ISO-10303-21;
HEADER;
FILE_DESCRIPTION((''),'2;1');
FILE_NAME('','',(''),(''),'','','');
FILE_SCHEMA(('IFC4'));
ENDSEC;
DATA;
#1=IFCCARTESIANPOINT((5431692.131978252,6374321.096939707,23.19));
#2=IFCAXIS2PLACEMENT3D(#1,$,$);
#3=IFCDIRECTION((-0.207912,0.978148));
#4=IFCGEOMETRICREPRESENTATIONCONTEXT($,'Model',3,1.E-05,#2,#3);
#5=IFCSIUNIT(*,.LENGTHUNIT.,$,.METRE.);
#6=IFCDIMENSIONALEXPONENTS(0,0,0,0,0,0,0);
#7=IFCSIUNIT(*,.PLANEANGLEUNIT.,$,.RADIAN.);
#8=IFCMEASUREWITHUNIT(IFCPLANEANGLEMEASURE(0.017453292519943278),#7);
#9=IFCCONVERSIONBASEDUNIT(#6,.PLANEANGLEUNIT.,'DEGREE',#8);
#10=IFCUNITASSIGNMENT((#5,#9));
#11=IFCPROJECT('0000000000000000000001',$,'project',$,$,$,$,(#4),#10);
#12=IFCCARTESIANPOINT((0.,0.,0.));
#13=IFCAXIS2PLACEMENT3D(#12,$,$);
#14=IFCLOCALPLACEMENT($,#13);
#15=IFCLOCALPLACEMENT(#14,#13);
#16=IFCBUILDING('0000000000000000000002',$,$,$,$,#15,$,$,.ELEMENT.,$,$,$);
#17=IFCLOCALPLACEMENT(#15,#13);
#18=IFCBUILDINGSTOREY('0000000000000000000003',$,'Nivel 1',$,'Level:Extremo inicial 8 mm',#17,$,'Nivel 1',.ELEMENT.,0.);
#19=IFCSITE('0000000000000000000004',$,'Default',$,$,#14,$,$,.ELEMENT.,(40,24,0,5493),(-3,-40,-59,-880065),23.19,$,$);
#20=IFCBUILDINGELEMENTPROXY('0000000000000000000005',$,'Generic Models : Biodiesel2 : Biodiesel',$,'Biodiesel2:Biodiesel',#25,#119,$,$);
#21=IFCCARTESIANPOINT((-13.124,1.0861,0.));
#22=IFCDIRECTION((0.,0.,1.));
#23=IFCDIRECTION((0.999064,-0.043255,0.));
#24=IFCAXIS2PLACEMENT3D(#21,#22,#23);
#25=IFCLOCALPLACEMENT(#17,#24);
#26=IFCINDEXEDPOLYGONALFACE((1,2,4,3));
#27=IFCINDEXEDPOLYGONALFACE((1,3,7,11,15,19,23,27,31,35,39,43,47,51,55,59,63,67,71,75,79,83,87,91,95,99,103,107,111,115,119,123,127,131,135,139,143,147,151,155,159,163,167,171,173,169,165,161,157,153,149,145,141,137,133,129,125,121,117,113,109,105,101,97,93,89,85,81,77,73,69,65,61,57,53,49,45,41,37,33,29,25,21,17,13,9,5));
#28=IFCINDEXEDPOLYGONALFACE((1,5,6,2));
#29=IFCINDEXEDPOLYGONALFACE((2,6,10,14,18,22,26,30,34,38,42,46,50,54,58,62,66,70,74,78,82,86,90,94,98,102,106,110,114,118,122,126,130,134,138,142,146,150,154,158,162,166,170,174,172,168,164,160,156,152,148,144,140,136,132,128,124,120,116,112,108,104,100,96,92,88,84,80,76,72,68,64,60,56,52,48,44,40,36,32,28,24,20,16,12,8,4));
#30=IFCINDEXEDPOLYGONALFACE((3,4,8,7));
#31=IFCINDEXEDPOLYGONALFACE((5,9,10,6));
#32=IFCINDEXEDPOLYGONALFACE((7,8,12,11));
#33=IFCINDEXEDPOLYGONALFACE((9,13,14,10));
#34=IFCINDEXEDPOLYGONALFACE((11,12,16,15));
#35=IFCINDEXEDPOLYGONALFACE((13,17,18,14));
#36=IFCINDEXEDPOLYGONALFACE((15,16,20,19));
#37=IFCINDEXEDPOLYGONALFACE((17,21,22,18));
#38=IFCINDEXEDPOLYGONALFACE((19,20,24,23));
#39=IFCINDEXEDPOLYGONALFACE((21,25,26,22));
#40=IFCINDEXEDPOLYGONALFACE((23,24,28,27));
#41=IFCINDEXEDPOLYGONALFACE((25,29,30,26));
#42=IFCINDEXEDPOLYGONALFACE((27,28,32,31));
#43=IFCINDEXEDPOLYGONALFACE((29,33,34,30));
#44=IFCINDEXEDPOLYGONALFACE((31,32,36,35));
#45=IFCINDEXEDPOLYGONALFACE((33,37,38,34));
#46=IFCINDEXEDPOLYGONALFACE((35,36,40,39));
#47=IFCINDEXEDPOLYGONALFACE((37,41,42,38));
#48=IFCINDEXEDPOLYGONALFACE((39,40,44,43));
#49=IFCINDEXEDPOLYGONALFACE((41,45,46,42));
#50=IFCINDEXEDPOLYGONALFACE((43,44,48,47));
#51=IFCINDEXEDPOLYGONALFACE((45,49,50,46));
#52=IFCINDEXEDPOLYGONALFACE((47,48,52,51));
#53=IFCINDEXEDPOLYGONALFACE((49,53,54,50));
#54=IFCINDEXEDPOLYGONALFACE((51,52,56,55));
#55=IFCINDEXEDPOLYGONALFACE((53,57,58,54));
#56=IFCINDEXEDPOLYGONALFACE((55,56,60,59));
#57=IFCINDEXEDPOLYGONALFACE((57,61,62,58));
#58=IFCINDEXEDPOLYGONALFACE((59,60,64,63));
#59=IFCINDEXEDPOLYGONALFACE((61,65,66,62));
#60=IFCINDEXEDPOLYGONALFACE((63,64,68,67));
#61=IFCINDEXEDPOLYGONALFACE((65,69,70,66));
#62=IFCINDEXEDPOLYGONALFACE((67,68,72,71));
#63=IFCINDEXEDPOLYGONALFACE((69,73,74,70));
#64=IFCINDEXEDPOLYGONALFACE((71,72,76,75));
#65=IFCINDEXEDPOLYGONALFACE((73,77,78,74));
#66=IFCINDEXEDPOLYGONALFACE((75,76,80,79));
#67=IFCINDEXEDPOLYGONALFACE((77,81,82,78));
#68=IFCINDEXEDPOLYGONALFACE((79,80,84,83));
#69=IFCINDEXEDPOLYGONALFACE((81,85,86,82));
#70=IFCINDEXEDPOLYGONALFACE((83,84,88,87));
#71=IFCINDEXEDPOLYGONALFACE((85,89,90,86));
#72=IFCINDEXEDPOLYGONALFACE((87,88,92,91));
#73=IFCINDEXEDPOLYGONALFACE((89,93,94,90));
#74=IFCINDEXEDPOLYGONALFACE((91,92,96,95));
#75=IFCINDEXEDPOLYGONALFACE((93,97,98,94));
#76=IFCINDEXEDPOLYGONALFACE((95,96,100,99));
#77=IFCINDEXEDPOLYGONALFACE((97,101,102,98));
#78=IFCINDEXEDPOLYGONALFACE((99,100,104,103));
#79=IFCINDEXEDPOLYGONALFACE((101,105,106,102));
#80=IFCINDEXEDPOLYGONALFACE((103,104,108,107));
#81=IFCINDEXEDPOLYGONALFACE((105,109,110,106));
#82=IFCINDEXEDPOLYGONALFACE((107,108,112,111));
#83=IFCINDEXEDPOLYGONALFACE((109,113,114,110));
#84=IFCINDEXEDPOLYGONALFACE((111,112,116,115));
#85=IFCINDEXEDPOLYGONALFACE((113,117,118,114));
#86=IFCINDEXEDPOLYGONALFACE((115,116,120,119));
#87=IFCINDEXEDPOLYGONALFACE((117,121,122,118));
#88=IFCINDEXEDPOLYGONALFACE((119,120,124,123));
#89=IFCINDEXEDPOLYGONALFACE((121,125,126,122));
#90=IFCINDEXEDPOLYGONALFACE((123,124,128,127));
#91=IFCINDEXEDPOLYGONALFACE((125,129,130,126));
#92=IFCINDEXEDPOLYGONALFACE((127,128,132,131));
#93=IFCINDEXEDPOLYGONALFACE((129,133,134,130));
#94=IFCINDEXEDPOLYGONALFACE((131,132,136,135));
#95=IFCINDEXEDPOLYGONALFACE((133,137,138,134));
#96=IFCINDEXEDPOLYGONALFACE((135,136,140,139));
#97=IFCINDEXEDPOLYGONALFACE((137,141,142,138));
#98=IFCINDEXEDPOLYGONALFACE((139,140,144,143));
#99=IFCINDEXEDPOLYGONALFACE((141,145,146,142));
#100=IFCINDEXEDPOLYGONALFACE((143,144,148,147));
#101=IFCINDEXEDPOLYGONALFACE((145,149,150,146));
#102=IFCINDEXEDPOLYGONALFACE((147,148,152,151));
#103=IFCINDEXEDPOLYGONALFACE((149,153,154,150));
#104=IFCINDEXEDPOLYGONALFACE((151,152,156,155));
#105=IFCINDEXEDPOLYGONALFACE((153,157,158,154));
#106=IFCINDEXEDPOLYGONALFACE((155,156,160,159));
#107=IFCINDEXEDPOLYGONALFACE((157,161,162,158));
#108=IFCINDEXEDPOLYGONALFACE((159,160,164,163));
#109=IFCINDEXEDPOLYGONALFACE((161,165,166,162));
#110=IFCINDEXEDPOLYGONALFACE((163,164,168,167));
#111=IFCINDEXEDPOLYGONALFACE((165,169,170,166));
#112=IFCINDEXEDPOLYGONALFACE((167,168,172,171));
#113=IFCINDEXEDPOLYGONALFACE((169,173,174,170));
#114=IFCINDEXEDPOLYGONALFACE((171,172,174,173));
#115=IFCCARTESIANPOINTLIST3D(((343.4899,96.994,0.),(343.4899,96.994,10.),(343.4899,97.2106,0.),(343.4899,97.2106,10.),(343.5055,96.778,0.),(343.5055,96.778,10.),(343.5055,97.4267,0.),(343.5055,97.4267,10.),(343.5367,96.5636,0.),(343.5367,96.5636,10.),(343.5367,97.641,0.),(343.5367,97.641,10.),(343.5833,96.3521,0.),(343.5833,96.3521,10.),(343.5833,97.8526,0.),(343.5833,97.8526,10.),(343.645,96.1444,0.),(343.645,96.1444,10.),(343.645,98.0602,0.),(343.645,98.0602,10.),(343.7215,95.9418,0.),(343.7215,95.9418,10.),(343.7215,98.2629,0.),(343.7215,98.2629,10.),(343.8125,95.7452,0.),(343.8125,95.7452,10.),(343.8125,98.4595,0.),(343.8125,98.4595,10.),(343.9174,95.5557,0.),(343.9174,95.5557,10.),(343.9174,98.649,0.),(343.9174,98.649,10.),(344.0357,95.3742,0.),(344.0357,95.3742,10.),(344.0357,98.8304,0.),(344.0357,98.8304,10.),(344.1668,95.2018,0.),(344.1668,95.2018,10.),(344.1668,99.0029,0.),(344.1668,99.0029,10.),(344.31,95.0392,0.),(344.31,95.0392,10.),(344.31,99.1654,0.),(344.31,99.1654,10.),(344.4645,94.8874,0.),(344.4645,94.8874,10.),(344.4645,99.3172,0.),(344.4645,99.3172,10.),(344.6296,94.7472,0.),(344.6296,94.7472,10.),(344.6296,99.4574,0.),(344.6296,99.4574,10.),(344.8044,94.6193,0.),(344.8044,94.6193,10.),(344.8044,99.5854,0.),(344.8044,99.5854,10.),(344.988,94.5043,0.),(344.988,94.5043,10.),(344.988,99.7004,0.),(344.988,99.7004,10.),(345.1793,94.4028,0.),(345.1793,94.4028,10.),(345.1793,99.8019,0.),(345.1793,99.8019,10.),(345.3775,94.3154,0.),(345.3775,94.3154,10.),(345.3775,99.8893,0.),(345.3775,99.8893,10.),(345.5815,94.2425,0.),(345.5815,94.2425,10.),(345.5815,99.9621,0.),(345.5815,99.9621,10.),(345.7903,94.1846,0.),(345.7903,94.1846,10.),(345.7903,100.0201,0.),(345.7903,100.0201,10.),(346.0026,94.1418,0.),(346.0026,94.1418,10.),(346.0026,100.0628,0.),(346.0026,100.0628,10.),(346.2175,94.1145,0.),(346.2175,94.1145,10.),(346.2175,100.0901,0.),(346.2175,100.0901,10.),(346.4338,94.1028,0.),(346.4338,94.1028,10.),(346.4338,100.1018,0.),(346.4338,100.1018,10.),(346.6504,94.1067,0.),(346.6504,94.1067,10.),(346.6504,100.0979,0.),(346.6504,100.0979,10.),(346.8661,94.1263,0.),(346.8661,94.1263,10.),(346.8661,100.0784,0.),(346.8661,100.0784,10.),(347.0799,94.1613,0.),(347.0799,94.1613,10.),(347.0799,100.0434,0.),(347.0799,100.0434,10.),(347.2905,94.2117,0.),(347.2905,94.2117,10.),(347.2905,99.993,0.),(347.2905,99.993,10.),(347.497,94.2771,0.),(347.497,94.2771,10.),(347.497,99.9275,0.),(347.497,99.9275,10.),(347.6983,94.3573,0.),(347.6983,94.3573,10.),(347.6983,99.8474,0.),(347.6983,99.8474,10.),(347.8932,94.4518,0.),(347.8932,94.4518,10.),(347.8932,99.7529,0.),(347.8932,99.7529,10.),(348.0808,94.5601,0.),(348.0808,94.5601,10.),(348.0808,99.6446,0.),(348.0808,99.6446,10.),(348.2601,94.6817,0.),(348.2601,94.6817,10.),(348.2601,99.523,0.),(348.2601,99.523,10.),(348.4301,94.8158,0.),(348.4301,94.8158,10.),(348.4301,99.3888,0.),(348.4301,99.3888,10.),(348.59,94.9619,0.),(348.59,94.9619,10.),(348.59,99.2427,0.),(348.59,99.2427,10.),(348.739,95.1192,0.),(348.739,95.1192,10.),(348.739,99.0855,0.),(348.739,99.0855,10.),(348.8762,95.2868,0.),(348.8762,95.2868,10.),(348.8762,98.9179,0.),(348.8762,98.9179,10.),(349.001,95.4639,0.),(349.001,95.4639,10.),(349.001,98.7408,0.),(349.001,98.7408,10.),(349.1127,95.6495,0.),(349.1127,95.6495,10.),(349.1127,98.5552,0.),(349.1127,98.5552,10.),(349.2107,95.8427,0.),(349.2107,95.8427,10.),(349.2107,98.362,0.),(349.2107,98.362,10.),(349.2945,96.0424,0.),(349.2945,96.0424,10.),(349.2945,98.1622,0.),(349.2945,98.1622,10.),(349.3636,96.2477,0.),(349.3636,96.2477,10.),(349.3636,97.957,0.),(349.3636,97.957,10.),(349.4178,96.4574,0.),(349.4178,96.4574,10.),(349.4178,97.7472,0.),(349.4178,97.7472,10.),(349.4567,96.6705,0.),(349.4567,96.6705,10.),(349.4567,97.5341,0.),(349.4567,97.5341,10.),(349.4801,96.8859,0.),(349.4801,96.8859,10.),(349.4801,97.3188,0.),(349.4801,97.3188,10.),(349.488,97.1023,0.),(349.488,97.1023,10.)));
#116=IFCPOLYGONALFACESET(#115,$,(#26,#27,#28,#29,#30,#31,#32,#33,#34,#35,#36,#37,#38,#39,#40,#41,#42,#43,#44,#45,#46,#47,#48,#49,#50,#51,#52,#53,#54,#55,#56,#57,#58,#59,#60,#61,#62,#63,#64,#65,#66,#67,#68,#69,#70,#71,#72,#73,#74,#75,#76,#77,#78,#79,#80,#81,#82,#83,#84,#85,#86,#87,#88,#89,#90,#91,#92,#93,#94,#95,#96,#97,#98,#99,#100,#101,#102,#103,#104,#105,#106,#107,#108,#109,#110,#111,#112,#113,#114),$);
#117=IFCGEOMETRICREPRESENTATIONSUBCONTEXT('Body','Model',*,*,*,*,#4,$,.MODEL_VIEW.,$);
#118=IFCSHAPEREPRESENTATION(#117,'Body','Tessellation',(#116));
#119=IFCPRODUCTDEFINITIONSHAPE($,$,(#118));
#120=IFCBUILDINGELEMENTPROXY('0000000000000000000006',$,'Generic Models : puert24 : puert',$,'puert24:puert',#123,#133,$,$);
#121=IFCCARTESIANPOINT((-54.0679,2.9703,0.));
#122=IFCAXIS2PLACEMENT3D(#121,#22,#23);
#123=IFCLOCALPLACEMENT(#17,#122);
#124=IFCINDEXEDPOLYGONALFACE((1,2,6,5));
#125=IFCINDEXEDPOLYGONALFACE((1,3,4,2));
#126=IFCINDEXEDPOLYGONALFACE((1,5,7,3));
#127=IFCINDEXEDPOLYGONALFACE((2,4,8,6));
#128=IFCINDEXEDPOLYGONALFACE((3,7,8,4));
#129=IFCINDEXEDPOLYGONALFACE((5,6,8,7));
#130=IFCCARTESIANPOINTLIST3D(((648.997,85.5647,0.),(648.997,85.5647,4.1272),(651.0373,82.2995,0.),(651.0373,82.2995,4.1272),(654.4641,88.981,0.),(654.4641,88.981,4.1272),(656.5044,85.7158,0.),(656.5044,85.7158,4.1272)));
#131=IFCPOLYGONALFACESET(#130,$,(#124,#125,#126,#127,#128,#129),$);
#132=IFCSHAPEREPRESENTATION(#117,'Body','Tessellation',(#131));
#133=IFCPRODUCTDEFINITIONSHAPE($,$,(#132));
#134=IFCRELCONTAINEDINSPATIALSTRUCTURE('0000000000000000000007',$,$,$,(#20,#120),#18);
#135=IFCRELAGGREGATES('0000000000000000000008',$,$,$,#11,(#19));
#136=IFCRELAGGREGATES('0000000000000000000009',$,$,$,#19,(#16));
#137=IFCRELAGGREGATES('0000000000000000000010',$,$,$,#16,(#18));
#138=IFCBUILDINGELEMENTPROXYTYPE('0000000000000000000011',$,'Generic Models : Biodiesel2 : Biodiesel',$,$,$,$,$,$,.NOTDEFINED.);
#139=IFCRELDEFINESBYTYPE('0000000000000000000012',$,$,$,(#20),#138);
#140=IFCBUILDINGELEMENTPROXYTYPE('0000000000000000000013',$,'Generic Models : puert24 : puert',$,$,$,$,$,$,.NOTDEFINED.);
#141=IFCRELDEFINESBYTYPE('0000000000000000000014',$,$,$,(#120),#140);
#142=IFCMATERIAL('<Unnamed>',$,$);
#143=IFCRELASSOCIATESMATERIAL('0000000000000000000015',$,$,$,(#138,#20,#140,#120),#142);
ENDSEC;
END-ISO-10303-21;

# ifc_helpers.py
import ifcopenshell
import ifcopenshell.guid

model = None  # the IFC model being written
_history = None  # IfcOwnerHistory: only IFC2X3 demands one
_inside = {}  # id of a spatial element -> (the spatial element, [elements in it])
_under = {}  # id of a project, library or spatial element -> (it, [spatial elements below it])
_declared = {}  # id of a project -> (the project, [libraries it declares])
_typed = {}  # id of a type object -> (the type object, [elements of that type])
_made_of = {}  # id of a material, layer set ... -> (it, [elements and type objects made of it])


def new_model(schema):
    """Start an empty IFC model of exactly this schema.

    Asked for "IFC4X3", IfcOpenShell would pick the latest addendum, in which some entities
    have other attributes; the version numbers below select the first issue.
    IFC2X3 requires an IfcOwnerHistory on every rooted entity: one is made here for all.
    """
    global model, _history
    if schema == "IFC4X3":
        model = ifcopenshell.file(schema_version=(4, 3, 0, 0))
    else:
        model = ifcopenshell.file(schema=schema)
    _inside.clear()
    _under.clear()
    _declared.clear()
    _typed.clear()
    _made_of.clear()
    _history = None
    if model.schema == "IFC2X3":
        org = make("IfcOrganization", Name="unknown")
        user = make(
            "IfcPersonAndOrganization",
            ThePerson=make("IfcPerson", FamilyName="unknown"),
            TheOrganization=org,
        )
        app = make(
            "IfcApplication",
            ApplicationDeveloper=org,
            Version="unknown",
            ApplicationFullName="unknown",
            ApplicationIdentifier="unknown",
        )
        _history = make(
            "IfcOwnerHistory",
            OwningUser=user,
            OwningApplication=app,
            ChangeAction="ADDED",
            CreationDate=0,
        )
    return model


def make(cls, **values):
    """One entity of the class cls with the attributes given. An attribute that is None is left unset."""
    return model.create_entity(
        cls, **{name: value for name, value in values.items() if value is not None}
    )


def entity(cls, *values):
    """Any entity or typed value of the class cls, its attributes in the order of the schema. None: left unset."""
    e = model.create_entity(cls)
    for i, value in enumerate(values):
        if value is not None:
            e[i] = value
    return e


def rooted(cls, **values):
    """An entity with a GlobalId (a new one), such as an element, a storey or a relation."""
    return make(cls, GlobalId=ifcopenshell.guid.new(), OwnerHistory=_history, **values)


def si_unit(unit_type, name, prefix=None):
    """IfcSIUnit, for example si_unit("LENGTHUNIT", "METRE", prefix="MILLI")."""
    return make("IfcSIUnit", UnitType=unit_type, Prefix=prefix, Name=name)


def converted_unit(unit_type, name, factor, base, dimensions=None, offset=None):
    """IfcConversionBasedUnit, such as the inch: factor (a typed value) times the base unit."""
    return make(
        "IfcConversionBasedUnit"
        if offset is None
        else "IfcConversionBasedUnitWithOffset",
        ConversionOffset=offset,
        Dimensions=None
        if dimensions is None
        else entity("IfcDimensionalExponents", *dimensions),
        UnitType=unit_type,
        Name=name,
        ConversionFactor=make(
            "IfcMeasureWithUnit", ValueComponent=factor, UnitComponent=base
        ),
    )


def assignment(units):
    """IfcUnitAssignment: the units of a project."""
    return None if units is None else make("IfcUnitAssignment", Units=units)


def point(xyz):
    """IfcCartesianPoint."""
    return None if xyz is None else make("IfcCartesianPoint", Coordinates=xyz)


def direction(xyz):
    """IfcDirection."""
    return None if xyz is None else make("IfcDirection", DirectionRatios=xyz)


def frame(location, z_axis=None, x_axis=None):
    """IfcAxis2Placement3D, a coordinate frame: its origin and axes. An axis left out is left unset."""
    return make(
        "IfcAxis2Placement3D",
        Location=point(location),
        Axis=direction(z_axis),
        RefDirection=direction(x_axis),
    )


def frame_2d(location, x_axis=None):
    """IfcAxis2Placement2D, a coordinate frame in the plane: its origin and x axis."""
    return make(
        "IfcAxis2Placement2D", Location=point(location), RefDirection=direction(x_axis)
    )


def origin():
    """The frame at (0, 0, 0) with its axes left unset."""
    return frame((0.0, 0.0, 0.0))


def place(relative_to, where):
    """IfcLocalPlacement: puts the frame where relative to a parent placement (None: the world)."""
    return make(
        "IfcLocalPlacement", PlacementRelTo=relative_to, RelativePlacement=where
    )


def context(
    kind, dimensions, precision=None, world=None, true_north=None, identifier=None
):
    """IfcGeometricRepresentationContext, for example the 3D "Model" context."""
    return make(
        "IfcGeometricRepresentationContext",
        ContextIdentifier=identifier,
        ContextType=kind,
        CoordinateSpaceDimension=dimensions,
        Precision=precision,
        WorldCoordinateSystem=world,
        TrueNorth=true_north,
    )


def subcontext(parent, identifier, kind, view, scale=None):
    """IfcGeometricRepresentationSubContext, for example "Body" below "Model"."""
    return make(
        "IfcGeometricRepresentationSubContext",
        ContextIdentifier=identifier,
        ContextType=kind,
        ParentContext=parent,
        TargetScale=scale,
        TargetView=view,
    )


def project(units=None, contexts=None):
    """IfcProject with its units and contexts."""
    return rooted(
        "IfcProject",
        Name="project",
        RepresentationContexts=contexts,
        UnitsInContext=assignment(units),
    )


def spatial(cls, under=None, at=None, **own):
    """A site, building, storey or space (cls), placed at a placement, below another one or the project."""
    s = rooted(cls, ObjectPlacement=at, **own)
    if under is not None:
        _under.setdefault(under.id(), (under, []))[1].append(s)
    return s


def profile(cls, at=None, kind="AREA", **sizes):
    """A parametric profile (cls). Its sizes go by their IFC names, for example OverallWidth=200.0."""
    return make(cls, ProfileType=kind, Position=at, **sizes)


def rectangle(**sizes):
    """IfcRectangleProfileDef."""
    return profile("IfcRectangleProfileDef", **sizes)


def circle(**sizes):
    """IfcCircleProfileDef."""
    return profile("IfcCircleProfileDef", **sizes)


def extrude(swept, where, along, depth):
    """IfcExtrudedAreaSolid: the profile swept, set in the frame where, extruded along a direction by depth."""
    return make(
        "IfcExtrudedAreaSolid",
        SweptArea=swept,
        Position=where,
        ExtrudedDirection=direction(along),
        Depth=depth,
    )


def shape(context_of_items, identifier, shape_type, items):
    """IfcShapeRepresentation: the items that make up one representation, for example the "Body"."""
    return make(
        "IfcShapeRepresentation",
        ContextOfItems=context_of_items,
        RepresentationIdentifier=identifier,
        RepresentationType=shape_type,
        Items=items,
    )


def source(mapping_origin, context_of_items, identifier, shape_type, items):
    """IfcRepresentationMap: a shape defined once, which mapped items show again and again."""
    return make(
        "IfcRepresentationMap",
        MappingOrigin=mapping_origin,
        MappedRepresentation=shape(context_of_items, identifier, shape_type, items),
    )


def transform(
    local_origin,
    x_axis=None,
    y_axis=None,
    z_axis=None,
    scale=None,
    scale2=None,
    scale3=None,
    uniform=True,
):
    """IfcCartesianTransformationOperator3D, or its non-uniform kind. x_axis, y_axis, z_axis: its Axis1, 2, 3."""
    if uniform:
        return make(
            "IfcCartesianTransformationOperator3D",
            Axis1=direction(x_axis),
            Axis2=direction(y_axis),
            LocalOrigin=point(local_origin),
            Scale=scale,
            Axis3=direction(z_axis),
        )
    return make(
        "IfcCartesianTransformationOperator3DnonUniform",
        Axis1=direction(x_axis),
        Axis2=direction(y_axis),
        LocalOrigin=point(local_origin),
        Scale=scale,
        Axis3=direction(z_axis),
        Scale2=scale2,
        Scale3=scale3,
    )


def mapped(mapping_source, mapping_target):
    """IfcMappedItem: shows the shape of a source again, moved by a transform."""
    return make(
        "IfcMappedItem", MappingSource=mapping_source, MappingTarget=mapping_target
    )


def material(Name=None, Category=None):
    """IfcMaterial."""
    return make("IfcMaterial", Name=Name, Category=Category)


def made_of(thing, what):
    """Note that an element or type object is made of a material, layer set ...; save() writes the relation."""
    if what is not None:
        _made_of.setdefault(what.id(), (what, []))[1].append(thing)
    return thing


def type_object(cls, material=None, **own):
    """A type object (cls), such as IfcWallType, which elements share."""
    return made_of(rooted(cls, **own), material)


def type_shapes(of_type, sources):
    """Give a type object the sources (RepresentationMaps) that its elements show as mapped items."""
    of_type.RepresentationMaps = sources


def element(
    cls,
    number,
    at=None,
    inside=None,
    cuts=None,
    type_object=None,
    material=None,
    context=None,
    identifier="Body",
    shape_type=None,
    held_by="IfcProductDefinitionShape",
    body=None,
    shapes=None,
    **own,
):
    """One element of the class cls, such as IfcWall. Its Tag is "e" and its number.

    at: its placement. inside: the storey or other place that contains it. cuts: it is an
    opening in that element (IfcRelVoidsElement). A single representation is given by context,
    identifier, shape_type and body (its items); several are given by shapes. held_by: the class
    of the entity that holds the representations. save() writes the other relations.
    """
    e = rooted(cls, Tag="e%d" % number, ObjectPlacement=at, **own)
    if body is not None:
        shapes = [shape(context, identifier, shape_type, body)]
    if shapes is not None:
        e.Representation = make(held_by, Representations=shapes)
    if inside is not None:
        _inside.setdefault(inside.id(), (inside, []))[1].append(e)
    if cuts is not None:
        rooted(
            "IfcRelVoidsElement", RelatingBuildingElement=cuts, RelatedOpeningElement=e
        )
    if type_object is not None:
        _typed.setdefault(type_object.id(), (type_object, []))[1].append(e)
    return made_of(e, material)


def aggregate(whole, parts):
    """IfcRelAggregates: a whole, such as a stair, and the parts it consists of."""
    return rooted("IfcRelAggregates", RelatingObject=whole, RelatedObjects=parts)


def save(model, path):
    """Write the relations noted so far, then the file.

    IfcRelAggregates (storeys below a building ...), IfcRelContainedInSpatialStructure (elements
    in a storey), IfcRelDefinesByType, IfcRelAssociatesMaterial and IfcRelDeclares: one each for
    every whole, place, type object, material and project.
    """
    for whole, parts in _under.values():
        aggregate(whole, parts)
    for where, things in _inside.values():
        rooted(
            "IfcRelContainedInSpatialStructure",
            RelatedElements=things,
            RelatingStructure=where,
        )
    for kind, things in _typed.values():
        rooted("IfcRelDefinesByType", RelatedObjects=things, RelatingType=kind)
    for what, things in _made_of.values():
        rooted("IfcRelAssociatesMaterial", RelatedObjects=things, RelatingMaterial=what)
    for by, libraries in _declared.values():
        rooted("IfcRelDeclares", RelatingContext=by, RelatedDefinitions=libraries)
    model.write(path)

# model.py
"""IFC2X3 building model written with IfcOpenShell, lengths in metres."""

from ifc_helpers import new_model, entity, si_unit, converted_unit, direction, frame, frame_2d, origin, place, context, subcontext, project, spatial, rectangle, circle, extrude, source, transform, mapped, material, type_object, type_shapes, element, save


model = new_model("IFC2X3")

# Units and contexts
model_context = context("Model", 3, precision=1e-05, world=frame((5431692.131978252, 6374321.096939707, 23.19)), true_north=direction((-0.207912, 0.978148)))
body_context = subcontext(model_context, "Body", "Model", "MODEL_VIEW")
ifc_project = project(units=[si_unit("LENGTHUNIT", "METRE"), converted_unit("PLANEANGLEUNIT", "DEGREE", entity("IfcPlaneAngleMeasure", 0.017453292519943278), si_unit("PLANEANGLEUNIT", "RADIAN"), dimensions=[0, 0, 0, 0, 0, 0, 0])], contexts=[model_context])

# Site, building, storey
site_placement = place(None, origin())
site = spatial("IfcSite", under=ifc_project, at=site_placement, Name="Default", CompositionType="ELEMENT", RefLatitude=(40, 24, 0, 5493), RefLongitude=(-3, -40, -59, -880065), RefElevation=23.19)
building_placement = place(site_placement, origin())
building = spatial("IfcBuilding", under=site, at=building_placement, CompositionType="ELEMENT")
storey_placement = place(building_placement, origin())
storey = spatial("IfcBuildingStorey", under=building, at=storey_placement, Name="Nivel 1", ObjectType="Level:Extremo inicial 8 mm", LongName="Nivel 1", CompositionType="ELEMENT", Elevation=0.0)

# Building element proxies
ifc_material_1 = material(Name="<Unnamed>")
building_element_proxy_type_1 = type_object("IfcBuildingElementProxyType", Name="Generic Models : Biodiesel2 : Biodiesel", PredefinedType="NOTDEFINED", material=ifc_material_1)
shared_shape_1 = source(origin(), body_context, "Body", "SweptSolid", [
    extrude(circle(Radius=3.0, at=frame_2d((0.0, 0.0), x_axis=(1.0, 0.0))), frame((346.488, 97.1023, 0.0)), (0.0, 0.0, 1.0), 10.0),
])
type_shapes(building_element_proxy_type_1, [shared_shape_1])
proxy_1_placement = place(storey_placement, frame((-13.124, 1.0861, 0.0), z_axis=(0.0, 0.0, 1.0), x_axis=(0.999064, -0.043255, 0.0)))
element("IfcBuildingElementProxy", 1, at=proxy_1_placement, inside=storey, type_object=building_element_proxy_type_1, material=ifc_material_1, Name="Generic Models : Biodiesel2 : Biodiesel", ObjectType="Biodiesel2:Biodiesel", context=body_context, shape_type="MappedRepresentation", body=[
    mapped(shared_shape_1, transform((0.0, 0.0, 0.0), scale=1.0)),
])
building_element_proxy_type_2 = type_object("IfcBuildingElementProxyType", Name="Generic Models : puert24 : puert", PredefinedType="NOTDEFINED", material=ifc_material_1)
shared_shape_2 = source(origin(), body_context, "Body", "SweptSolid", [
    extrude(rectangle(XDim=6.4467, YDim=3.8503, at=frame_2d((0.0, 0.0), x_axis=(1.0, 0.0))), frame((652.7507, 85.6402, 0.0), z_axis=(0.0, 0.0, 1.0), x_axis=(-0.848048, -0.529919, 0.0)), (0.0, 0.0, 1.0), 4.1272),
])
type_shapes(building_element_proxy_type_2, [shared_shape_2])
proxy_2_placement = place(storey_placement, frame((-54.0679, 2.9703, 0.0), z_axis=(0.0, 0.0, 1.0), x_axis=(0.999064, -0.043255, 0.0)))
element("IfcBuildingElementProxy", 2, at=proxy_2_placement, inside=storey, type_object=building_element_proxy_type_2, material=ifc_material_1, Name="Generic Models : puert24 : puert", ObjectType="puert24:puert", context=body_context, shape_type="MappedRepresentation", body=[
    mapped(shared_shape_2, transform((0.0, 0.0, 0.0), scale=1.0)),
])

save(model, "model.ifc")
